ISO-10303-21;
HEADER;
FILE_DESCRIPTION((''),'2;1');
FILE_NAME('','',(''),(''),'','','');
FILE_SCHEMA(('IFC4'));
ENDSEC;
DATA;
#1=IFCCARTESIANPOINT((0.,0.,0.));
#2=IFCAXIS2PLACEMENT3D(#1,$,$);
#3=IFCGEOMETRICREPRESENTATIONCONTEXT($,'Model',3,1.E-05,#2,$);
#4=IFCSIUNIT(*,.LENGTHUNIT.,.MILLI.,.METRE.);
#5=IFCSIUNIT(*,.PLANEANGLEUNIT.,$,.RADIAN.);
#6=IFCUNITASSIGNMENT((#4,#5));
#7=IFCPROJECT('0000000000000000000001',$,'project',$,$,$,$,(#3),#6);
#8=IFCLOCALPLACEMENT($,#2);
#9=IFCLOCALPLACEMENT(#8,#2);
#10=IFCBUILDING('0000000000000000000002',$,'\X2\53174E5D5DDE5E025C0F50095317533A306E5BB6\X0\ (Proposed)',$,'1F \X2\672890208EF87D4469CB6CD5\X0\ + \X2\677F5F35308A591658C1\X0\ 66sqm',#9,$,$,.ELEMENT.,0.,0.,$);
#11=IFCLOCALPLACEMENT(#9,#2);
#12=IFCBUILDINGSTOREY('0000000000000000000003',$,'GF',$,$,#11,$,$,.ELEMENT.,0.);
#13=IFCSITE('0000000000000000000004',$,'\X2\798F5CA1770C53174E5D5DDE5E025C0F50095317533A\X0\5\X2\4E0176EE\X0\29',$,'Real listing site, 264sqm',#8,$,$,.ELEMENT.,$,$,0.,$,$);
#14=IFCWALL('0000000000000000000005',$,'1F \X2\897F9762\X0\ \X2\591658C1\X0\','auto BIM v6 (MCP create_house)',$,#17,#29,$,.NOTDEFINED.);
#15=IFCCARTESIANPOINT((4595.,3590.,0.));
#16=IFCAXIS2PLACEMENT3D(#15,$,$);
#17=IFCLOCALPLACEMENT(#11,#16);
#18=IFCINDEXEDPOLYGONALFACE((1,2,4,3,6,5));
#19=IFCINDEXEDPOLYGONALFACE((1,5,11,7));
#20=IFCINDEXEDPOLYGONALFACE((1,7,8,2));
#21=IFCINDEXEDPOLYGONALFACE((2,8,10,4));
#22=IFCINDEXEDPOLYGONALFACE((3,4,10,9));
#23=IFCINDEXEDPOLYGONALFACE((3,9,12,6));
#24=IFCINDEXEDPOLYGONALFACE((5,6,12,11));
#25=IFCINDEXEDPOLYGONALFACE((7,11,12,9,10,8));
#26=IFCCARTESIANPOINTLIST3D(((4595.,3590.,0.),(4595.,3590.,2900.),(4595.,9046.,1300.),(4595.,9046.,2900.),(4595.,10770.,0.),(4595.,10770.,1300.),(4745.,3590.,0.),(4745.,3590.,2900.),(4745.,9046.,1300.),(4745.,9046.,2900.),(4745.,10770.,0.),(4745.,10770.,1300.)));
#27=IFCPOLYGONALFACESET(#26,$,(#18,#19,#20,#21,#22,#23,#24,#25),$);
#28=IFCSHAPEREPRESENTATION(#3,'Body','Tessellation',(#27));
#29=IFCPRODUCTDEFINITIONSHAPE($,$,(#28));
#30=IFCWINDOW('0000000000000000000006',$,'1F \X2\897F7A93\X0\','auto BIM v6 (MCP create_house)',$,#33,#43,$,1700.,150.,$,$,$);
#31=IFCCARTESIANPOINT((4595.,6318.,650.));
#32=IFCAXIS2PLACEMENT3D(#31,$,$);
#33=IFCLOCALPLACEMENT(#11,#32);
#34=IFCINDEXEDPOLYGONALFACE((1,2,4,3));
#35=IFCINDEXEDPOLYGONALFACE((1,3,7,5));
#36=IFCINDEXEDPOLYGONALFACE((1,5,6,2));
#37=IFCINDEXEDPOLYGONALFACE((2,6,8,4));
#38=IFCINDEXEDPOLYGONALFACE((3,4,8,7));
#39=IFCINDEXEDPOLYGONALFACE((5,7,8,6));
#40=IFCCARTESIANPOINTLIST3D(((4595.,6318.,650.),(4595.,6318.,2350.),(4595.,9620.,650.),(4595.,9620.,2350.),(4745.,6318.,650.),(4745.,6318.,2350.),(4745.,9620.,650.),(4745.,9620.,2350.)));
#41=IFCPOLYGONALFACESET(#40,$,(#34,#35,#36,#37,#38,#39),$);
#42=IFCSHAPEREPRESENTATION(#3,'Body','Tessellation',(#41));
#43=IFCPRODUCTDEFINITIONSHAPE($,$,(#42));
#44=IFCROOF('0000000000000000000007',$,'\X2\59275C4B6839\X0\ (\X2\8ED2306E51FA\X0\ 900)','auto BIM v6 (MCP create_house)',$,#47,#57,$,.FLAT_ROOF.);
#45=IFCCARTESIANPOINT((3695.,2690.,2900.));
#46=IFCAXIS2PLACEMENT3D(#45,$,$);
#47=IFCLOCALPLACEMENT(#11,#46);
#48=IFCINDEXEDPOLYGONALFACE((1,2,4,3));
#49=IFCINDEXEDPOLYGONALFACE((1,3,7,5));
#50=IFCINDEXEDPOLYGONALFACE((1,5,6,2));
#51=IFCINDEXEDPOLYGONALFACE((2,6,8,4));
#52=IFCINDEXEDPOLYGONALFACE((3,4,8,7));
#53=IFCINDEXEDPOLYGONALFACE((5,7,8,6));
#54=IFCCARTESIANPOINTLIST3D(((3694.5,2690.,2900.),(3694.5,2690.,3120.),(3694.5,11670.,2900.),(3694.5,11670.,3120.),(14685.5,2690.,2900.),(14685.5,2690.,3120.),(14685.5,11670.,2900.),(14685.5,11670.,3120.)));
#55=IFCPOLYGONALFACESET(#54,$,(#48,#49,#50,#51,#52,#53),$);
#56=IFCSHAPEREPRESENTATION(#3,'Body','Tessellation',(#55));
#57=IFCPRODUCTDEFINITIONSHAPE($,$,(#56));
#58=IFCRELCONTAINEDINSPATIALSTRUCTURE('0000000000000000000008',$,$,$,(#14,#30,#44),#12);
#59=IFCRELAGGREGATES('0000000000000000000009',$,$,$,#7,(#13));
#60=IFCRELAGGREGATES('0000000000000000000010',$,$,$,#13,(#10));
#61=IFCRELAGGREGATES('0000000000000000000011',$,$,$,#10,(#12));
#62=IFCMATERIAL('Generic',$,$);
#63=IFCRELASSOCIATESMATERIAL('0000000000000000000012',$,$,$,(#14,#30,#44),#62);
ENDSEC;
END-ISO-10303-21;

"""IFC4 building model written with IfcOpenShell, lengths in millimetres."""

from ifc_helpers import new_model, si_unit, frame, frame_2d, origin, place, context, project, spatial, rectangle, extrude, material, element, fill, save


model = new_model("IFC4")

# Units and contexts
model_context = context("Model", 3, precision=1e-05, world=origin())
ifc_project = project(units=[si_unit("LENGTHUNIT", "METRE", prefix="MILLI"), si_unit("PLANEANGLEUNIT", "RADIAN")], contexts=[model_context])

# Site, building, storey
site_placement = place(None, origin())
site = spatial("IfcSite", under=ifc_project, at=site_placement, Name="福岡県北九州市小倉北区5丁目29", ObjectType="Real listing site, 264sqm", CompositionType="ELEMENT", RefElevation=0.0)
building_placement = place(site_placement, origin())
building = spatial("IfcBuilding", under=site, at=building_placement, Name="北九州市小倉北区の家 (Proposed)", ObjectType="1F 木造軸組構法 + 板張り外壁 66sqm", CompositionType="ELEMENT", ElevationOfRefHeight=0.0, ElevationOfTerrain=0.0)
storey_placement = place(building_placement, origin())
storey = spatial("IfcBuildingStorey", under=building, at=storey_placement, Name="GF", CompositionType="ELEMENT", Elevation=0.0)

# Shared definitions
ifc_material = material(Name="Generic")

# Wall, opening, window
wall_1_placement = place(storey_placement, frame((4595.0, 3590.0, 0.0)))
wall_1 = element("IfcWall", 1, at=wall_1_placement, inside=storey, material=ifc_material, Name="1F 西面 外壁", Description="auto BIM v6 (MCP create_house)", PredefinedType="NOTDEFINED", context=model_context, shape_type="SweptSolid", body=[
    extrude(rectangle(XDim=150.0, YDim=7180.0, at=frame_2d((75.0, 3590.0))), frame((4595.0, 3590.0, 0.0)), (0.0, 0.0, 1.0), 2900.0),
])
opening_1_placement = place(storey_placement, frame((4595.0, 6318.0, 650.0)))
opening_1 = element("IfcOpeningElement", 2, at=opening_1_placement, cuts=wall_1, PredefinedType="NOTDEFINED", context=model_context, shape_type="SweptSolid", body=[
    extrude(rectangle(XDim=150.0, YDim=3302.0, at=frame_2d((75.0, 1651.0))), frame((4595.0, 6318.0, 650.0)), (0.0, 0.0, 1.0), 1700.0),
])
window_1_placement = place(storey_placement, frame((4595.0, 6318.0, 650.0)))
window_1 = element("IfcWindow", 3, at=window_1_placement, inside=storey, material=ifc_material, Name="1F 西窓", Description="auto BIM v6 (MCP create_house)", OverallHeight=1700.0, OverallWidth=150.0, context=model_context, shape_type="SweptSolid", body=[
    extrude(rectangle(XDim=150.0, YDim=3302.0, at=frame_2d((75.0, 1651.0))), frame((4595.0, 6318.0, 650.0)), (0.0, 0.0, 1.0), 1700.0),
])
fill(opening_1, window_1)

# Roof
roof_placement = place(storey_placement, frame((3695.0, 2690.0, 2900.0)))
element("IfcRoof", 4, at=roof_placement, inside=storey, material=ifc_material, Name="大屋根 (軒の出 900)", Description="auto BIM v6 (MCP create_house)", PredefinedType="FLAT_ROOF", context=model_context, shape_type="SweptSolid", body=[
    extrude(rectangle(XDim=10991.0, YDim=8980.0, at=frame_2d((5495.0, 4490.0))), frame((3695.0, 2690.0, 2900.0)), (0.0, 0.0, 1.0), 220.0),
])

save(model, "model.ifc")
